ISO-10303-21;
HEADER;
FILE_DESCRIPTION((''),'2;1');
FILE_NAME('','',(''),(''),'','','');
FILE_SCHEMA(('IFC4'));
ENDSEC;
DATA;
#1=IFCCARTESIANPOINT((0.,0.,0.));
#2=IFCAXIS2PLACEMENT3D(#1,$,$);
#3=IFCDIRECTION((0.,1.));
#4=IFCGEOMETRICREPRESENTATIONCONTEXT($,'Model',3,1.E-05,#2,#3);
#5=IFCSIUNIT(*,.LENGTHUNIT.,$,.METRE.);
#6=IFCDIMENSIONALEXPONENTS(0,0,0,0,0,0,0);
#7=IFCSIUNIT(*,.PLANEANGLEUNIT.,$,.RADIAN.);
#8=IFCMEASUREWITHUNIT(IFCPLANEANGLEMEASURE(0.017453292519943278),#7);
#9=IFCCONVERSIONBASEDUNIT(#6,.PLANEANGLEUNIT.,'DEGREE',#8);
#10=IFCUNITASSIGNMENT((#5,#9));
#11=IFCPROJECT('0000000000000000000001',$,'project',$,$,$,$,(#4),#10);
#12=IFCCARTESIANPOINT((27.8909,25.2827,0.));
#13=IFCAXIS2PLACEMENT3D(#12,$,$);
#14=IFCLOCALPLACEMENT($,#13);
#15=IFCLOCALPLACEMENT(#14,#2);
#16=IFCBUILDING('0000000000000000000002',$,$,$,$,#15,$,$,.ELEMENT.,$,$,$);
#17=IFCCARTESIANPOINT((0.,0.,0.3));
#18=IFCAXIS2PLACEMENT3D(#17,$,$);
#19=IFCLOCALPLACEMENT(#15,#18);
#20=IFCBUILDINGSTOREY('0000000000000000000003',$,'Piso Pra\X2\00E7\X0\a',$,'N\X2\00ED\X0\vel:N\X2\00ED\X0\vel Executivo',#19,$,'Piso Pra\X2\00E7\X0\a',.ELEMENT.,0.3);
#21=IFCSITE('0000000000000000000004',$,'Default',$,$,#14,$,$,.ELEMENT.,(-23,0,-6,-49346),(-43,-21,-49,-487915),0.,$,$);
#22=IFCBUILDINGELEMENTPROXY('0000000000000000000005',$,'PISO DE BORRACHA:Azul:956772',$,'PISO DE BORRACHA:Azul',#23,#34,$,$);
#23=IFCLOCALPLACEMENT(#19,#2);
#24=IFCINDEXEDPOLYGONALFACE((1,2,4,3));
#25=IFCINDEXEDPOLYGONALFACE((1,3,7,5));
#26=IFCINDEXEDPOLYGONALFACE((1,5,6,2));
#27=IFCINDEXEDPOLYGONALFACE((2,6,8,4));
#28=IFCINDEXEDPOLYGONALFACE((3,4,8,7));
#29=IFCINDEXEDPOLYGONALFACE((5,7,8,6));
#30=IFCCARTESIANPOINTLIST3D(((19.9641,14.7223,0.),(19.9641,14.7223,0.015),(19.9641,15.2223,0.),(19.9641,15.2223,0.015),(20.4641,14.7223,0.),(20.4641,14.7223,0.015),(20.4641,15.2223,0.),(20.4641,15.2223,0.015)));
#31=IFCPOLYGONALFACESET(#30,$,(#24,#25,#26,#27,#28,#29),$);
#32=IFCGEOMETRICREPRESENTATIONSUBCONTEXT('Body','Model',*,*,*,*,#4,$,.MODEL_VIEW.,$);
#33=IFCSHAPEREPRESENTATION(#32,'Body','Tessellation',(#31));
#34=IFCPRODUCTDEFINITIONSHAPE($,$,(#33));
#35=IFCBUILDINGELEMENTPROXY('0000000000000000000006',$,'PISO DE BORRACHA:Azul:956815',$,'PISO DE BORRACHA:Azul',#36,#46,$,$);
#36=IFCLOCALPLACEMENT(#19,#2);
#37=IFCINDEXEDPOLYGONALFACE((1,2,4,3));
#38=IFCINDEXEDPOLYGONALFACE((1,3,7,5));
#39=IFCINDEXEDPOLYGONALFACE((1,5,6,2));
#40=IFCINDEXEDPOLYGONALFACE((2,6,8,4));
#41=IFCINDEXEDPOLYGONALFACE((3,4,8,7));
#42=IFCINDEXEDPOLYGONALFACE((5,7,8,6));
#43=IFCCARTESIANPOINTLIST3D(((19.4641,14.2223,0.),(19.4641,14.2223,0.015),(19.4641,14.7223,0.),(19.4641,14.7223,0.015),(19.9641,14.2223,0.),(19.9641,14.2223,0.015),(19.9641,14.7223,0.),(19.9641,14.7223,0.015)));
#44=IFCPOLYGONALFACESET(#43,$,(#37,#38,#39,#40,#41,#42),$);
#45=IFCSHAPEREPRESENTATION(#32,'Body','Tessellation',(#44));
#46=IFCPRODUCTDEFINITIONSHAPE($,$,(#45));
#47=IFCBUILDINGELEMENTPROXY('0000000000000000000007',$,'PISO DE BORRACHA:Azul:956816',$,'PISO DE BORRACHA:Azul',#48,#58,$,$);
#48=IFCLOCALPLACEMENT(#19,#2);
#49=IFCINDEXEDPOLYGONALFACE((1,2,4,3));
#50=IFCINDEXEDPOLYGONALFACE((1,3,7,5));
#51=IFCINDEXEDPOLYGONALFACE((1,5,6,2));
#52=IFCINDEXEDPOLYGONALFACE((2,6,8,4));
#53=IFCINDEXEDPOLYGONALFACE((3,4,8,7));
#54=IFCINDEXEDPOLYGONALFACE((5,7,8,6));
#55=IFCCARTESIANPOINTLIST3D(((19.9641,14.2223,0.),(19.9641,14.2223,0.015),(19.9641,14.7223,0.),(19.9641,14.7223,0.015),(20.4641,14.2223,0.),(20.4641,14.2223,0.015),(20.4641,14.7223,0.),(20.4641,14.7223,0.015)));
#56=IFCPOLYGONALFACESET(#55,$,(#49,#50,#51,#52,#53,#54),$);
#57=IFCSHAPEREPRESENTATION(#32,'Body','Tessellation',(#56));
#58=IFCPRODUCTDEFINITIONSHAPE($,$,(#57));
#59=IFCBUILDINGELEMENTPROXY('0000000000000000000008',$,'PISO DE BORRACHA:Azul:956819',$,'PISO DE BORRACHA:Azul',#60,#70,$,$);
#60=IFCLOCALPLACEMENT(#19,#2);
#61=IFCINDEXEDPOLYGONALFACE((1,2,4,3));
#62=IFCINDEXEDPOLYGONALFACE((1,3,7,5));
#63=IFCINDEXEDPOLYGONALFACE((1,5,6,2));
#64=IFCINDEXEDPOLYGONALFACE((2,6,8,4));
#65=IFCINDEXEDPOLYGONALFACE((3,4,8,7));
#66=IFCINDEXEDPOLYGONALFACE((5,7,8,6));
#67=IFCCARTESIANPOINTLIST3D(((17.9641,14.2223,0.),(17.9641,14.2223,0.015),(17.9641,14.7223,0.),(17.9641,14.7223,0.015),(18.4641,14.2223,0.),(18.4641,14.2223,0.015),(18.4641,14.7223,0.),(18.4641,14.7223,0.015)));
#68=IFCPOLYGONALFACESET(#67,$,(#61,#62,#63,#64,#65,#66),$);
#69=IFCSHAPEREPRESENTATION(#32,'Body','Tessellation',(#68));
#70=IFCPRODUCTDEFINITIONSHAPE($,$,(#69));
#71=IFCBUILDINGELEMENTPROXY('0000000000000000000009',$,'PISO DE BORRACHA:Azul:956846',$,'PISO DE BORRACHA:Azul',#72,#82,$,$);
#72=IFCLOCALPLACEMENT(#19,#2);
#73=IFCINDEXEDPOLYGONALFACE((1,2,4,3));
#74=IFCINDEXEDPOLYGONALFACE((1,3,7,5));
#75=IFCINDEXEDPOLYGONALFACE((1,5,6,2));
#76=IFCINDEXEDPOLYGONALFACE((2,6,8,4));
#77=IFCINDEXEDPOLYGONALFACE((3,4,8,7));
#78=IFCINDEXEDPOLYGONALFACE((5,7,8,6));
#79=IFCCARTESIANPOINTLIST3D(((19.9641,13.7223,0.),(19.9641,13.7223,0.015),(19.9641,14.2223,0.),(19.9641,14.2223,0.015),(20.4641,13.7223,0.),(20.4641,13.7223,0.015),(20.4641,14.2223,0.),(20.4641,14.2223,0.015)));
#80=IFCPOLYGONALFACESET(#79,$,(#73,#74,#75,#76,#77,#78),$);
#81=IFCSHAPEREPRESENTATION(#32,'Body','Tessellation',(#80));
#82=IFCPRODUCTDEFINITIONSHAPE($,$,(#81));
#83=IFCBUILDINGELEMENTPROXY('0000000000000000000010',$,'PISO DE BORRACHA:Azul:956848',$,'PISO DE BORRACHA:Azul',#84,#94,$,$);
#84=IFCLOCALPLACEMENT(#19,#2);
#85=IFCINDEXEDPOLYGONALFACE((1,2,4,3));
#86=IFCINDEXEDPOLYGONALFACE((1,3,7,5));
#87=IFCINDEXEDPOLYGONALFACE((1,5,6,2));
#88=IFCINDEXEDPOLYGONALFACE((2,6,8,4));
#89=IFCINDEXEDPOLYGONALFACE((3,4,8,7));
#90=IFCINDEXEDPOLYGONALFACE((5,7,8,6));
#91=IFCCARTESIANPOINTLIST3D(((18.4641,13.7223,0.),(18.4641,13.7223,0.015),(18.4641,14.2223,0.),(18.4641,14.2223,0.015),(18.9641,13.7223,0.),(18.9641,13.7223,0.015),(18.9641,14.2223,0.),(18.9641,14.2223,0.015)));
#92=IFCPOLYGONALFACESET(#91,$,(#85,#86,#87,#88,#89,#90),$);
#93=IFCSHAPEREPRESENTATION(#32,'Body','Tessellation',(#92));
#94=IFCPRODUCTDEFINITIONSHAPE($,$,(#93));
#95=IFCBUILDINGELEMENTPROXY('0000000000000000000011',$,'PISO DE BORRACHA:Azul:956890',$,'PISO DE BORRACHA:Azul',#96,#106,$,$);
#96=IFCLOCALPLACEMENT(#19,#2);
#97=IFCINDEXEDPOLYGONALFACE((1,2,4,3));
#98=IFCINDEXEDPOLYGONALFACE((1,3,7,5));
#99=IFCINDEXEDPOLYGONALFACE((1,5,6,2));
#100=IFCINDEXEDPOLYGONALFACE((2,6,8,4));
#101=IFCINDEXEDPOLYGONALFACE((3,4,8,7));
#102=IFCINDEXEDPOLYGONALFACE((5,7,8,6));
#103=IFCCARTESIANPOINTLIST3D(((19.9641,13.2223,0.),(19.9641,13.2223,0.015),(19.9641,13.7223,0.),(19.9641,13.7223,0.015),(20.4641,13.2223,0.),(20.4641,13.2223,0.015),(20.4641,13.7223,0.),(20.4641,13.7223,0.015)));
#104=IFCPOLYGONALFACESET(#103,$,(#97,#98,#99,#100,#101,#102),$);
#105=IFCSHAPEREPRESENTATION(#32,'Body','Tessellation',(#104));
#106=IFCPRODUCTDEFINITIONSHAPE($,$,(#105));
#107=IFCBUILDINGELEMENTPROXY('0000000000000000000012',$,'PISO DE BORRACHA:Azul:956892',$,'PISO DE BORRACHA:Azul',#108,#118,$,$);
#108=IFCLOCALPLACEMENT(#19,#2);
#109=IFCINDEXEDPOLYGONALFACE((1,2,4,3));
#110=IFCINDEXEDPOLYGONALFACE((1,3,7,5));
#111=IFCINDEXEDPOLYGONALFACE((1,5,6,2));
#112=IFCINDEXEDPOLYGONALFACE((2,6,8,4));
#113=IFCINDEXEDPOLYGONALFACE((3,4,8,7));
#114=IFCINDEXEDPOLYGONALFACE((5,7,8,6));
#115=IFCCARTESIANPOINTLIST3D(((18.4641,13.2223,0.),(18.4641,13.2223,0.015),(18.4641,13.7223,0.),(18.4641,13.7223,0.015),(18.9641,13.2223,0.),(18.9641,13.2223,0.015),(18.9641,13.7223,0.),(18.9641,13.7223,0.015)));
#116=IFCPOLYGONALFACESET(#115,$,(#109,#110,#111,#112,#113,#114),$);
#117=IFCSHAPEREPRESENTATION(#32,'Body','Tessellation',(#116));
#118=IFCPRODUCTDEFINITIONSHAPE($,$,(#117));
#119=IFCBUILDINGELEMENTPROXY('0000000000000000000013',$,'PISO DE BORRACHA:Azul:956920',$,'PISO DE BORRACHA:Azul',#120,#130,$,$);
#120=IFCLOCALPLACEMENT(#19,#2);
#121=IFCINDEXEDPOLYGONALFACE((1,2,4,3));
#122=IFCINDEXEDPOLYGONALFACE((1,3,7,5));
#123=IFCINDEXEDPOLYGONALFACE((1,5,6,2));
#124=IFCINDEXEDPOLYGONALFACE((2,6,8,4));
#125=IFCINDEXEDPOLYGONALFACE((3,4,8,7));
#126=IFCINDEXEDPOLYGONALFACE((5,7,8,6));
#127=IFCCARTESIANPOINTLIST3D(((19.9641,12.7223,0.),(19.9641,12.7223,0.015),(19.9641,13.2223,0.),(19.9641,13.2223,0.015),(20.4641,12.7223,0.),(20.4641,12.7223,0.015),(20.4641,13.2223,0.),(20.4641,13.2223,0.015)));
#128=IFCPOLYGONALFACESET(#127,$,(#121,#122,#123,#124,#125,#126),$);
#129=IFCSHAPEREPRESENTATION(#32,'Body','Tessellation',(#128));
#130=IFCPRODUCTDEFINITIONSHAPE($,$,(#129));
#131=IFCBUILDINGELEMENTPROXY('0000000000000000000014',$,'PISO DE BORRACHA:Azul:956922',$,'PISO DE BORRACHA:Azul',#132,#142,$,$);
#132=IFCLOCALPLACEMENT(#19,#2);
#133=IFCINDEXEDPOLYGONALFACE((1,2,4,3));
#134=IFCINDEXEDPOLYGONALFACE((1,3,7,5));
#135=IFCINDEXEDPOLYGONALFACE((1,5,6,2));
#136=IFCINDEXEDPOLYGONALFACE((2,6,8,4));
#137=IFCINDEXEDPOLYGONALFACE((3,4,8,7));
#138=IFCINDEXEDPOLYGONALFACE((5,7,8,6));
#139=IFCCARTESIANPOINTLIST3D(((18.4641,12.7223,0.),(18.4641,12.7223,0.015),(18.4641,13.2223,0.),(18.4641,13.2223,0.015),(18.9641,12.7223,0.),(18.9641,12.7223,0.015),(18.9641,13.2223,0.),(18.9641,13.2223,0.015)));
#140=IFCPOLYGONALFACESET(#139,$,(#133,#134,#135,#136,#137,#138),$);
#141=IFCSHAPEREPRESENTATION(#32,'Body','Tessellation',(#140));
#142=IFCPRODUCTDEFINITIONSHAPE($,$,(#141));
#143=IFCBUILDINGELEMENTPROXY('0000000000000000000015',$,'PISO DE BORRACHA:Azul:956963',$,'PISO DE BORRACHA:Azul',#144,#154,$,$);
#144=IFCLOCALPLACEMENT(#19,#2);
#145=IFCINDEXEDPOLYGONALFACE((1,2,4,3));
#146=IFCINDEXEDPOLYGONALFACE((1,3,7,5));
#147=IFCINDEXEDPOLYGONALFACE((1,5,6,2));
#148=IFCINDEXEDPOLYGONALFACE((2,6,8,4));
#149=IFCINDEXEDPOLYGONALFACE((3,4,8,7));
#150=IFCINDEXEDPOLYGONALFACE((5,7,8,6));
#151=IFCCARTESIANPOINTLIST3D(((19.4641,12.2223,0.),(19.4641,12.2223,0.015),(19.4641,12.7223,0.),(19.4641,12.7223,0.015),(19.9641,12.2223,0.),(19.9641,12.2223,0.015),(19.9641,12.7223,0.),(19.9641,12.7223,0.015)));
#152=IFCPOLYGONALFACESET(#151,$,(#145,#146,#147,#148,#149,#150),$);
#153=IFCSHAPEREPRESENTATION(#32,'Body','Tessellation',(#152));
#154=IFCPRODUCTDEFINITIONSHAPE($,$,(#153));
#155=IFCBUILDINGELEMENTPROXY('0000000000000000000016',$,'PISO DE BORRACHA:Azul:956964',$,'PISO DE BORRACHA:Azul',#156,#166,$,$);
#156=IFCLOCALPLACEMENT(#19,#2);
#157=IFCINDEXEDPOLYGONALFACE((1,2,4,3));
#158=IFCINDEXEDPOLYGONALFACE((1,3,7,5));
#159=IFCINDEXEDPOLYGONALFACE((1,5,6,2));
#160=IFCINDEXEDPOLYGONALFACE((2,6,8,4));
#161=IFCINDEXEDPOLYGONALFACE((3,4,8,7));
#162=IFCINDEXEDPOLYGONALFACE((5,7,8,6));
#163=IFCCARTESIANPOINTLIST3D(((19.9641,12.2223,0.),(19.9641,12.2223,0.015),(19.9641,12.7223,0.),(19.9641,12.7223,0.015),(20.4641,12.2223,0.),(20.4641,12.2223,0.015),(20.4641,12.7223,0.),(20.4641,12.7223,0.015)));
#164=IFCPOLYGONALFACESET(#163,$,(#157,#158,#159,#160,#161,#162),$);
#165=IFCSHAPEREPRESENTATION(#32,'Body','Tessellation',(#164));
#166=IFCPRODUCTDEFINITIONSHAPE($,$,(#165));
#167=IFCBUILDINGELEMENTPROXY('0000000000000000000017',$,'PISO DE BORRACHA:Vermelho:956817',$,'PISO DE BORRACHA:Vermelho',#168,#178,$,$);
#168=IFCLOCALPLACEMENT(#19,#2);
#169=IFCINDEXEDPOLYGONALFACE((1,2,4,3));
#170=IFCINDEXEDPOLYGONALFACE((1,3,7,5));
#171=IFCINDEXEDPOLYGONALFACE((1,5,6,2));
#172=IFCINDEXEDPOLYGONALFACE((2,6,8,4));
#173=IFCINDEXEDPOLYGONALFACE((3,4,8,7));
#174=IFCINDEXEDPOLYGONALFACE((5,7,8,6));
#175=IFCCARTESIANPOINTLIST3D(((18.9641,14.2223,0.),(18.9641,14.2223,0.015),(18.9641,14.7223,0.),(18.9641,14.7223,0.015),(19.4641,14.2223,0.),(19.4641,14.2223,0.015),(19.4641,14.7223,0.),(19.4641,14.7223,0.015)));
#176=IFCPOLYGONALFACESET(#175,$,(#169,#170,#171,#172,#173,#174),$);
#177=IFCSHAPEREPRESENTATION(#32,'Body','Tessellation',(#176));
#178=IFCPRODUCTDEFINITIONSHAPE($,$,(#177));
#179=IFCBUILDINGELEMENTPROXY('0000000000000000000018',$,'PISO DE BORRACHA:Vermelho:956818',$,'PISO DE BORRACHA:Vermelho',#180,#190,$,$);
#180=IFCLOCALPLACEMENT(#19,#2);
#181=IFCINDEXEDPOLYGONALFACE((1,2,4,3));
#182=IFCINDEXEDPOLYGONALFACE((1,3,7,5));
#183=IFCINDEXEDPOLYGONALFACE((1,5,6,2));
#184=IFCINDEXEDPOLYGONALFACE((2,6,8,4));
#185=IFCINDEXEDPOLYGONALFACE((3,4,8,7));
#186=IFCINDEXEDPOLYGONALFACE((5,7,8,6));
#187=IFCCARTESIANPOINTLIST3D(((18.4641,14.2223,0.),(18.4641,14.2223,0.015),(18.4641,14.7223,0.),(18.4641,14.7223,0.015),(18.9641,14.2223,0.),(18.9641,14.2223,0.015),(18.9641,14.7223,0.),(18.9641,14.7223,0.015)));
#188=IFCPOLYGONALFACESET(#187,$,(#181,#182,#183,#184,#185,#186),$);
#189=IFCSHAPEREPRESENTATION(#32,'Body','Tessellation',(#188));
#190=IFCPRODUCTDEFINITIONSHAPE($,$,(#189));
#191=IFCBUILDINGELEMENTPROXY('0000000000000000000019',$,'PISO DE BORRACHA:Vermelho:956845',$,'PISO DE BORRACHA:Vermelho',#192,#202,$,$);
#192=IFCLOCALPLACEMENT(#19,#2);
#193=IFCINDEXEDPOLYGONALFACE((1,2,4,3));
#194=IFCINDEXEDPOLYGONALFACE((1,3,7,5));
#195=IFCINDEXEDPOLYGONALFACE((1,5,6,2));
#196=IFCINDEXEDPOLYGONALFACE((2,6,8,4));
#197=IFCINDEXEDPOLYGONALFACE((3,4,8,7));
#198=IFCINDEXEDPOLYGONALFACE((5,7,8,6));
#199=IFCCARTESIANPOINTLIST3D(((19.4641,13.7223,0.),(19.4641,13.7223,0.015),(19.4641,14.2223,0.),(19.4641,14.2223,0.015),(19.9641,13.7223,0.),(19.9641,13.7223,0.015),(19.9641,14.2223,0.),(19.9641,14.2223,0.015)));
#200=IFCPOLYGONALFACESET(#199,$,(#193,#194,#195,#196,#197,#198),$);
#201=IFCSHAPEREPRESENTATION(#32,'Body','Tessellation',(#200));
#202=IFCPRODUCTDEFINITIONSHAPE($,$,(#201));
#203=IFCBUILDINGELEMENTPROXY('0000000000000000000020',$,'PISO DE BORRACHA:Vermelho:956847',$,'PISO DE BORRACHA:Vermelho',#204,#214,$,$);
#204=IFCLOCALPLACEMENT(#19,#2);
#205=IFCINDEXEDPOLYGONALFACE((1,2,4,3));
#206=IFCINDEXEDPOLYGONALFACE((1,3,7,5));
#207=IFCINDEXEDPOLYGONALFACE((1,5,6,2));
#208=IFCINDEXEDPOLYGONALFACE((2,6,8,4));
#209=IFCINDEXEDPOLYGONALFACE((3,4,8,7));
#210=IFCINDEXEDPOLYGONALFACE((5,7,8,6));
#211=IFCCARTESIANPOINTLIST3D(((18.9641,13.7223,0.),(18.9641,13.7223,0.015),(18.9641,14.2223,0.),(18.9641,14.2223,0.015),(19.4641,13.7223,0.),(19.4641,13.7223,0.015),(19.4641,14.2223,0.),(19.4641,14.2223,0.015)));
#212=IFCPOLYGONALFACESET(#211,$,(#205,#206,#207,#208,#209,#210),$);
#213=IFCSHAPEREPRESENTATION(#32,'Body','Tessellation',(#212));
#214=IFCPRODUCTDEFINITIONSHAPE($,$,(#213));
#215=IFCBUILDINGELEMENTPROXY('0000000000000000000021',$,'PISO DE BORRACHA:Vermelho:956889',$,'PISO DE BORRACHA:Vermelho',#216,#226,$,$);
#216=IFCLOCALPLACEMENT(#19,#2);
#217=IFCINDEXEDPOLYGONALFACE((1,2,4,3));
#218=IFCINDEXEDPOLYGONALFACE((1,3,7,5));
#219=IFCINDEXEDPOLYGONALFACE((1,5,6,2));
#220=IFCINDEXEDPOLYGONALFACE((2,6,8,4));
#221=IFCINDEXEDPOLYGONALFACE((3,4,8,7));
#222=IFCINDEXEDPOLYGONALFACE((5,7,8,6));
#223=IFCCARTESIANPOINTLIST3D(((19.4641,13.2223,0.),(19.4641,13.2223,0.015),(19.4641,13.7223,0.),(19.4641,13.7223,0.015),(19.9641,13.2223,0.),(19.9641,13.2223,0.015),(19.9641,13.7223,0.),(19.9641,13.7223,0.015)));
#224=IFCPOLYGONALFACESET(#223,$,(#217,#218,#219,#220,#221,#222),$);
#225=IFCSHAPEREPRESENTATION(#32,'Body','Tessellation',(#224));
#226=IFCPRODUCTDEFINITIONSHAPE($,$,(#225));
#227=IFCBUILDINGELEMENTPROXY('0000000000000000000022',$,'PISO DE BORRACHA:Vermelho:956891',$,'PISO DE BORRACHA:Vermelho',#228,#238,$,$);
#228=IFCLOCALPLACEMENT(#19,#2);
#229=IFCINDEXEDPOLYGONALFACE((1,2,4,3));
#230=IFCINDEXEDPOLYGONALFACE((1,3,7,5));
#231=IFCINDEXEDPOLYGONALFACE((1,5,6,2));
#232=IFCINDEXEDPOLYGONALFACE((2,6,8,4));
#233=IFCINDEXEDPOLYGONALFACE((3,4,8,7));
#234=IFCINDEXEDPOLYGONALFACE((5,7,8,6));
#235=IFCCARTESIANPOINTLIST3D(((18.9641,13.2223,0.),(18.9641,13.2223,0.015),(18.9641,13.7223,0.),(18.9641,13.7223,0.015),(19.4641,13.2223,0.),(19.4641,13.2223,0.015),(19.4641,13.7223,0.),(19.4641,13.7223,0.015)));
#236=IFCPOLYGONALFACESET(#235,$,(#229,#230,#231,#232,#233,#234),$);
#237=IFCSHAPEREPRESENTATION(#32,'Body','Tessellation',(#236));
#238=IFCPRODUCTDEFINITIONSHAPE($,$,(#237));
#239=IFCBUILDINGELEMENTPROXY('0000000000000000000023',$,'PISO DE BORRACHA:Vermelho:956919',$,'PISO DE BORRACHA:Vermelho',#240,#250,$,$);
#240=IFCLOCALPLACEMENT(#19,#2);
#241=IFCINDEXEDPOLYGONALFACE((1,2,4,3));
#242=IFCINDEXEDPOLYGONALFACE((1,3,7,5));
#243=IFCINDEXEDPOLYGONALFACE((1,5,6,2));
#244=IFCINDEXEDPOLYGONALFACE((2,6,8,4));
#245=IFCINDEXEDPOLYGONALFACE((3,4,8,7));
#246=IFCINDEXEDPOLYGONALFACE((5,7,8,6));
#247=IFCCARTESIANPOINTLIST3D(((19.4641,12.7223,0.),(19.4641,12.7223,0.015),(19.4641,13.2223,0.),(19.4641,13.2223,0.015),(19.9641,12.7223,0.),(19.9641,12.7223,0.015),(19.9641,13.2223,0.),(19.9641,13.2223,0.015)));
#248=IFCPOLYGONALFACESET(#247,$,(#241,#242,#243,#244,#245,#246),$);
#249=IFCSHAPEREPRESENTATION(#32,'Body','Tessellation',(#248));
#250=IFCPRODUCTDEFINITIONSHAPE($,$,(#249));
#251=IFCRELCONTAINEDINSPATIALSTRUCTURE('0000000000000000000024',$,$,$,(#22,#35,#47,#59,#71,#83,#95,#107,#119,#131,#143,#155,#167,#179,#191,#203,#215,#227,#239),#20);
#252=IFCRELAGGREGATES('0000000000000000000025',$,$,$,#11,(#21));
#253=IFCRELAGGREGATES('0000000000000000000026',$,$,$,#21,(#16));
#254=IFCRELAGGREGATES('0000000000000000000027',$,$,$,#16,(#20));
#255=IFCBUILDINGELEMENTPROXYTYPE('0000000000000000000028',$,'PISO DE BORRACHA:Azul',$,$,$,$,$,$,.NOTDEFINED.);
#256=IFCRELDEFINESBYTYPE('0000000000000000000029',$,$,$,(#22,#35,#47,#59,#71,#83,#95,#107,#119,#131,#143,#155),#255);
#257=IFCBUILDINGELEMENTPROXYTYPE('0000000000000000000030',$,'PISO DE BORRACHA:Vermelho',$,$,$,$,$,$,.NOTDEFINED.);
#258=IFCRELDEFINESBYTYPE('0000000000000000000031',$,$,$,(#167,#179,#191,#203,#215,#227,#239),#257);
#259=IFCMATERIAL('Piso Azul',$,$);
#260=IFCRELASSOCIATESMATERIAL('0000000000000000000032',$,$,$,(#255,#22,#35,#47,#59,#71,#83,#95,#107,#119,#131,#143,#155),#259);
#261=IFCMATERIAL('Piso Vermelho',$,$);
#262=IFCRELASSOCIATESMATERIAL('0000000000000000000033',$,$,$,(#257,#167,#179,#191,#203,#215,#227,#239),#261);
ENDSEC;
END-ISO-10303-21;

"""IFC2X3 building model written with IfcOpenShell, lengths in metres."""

from ifc_helpers import new_model, entity, si_unit, converted_unit, direction, frame, origin, origin_2d_with_axis, place, context, subcontext, project, spatial, rectangle, extrude, source, transform, mapped, material, type_object, type_shapes, element, save


model = new_model("IFC2X3")

# Units and contexts
model_context = context("Model", 3, precision=1e-05, world=origin(), true_north=direction((0.0, 1.0)))
body_context = subcontext(model_context, "Body", "Model", "MODEL_VIEW")
ifc_project = project(units=[si_unit("LENGTHUNIT", "METRE"), converted_unit("PLANEANGLEUNIT", "DEGREE", entity("IfcPlaneAngleMeasure", 0.017453292519943278), si_unit("PLANEANGLEUNIT", "RADIAN"), dimensions=[0, 0, 0, 0, 0, 0, 0])], contexts=[model_context])

# Site, building, storey
site_placement = place(None, frame((27.8909, 25.2827, 0.0)))
site = spatial("IfcSite", under=ifc_project, at=site_placement, Name="Default", CompositionType="ELEMENT", RefLatitude=(-23, 0, -6, -49346), RefLongitude=(-43, -21, -49, -487915), RefElevation=0.0)
building_placement = place(site_placement, origin())
building = spatial("IfcBuilding", under=site, at=building_placement, CompositionType="ELEMENT")
storey_placement = place(building_placement, frame((0.0, 0.0, 0.3)))
storey = spatial("IfcBuildingStorey", under=building, at=storey_placement, Name="Piso Praça", ObjectType="Nível:Nível Executivo", LongName="Piso Praça", CompositionType="ELEMENT", Elevation=0.3)

# Building element proxies
ifc_material_1 = material(Name="Piso Azul")
building_element_proxy_type_1 = type_object("IfcBuildingElementProxyType", Name="PISO DE BORRACHA:Azul", PredefinedType="NOTDEFINED", material=ifc_material_1)
shared_shape_1 = source(origin(), body_context, "Body", "SweptSolid", [
    extrude(rectangle(XDim=0.5, YDim=0.5, at=origin_2d_with_axis()), frame((0.25, 0.25, 0.0), z_axis=(0.0, 0.0, 1.0), x_axis=(-1.0, 0.0, 0.0)), (0.0, 0.0, 1.0), 0.015),
])
type_shapes(building_element_proxy_type_1, [shared_shape_1])
for number, where, name in (
    (1, (19.9641, 14.7223, 0.0), "PISO DE BORRACHA:Azul:956772"),
    (2, (19.4641, 14.2223, 0.0), "PISO DE BORRACHA:Azul:956815"),
    (3, (19.9641, 14.2223, 0.0), "PISO DE BORRACHA:Azul:956816"),
    (4, (17.9641, 14.2223, 0.0), "PISO DE BORRACHA:Azul:956819"),
    (5, (19.9641, 13.7223, 0.0), "PISO DE BORRACHA:Azul:956846"),
    (6, (18.4641, 13.7223, 0.0), "PISO DE BORRACHA:Azul:956848"),
    (7, (19.9641, 13.2223, 0.0), "PISO DE BORRACHA:Azul:956890"),
    (8, (18.4641, 13.2223, 0.0), "PISO DE BORRACHA:Azul:956892"),
    (9, (19.9641, 12.7223, 0.0), "PISO DE BORRACHA:Azul:956920"),
    (10, (18.4641, 12.7223, 0.0), "PISO DE BORRACHA:Azul:956922"),
    (11, (19.4641, 12.2223, 0.0), "PISO DE BORRACHA:Azul:956963"),
    (12, (19.9641, 12.2223, 0.0), "PISO DE BORRACHA:Azul:956964"),
):
    element("IfcBuildingElementProxy", number, at=place(storey_placement, frame(where)), inside=storey, type_object=building_element_proxy_type_1, material=ifc_material_1, Name=name, ObjectType="PISO DE BORRACHA:Azul", context=body_context, shape_type="MappedRepresentation", body=[
        mapped(shared_shape_1, transform((0.0, 0.0, 0.0), scale=1.0)),
    ])
ifc_material_2 = material(Name="Piso Vermelho")
building_element_proxy_type_2 = type_object("IfcBuildingElementProxyType", Name="PISO DE BORRACHA:Vermelho", PredefinedType="NOTDEFINED", material=ifc_material_2)
shared_shape_2 = source(origin(), body_context, "Body", "SweptSolid", [
    extrude(rectangle(XDim=0.5, YDim=0.5, at=origin_2d_with_axis()), frame((0.25, 0.25, 0.0), z_axis=(0.0, 0.0, 1.0), x_axis=(-1.0, 0.0, 0.0)), (0.0, 0.0, 1.0), 0.015),
])
type_shapes(building_element_proxy_type_2, [shared_shape_2])
for number, where, name in (
    (13, (18.9641, 14.2223, 0.0), "PISO DE BORRACHA:Vermelho:956817"),
    (14, (18.4641, 14.2223, 0.0), "PISO DE BORRACHA:Vermelho:956818"),
    (15, (19.4641, 13.7223, 0.0), "PISO DE BORRACHA:Vermelho:956845"),
    (16, (18.9641, 13.7223, 0.0), "PISO DE BORRACHA:Vermelho:956847"),
    (17, (19.4641, 13.2223, 0.0), "PISO DE BORRACHA:Vermelho:956889"),
    (18, (18.9641, 13.2223, 0.0), "PISO DE BORRACHA:Vermelho:956891"),
    (19, (19.4641, 12.7223, 0.0), "PISO DE BORRACHA:Vermelho:956919"),
):
    element("IfcBuildingElementProxy", number, at=place(storey_placement, frame(where)), inside=storey, type_object=building_element_proxy_type_2, material=ifc_material_2, Name=name, ObjectType="PISO DE BORRACHA:Vermelho", context=body_context, shape_type="MappedRepresentation", body=[
        mapped(shared_shape_2, transform((0.0, 0.0, 0.0), scale=1.0)),
    ])

save(model, "model.ifc")
